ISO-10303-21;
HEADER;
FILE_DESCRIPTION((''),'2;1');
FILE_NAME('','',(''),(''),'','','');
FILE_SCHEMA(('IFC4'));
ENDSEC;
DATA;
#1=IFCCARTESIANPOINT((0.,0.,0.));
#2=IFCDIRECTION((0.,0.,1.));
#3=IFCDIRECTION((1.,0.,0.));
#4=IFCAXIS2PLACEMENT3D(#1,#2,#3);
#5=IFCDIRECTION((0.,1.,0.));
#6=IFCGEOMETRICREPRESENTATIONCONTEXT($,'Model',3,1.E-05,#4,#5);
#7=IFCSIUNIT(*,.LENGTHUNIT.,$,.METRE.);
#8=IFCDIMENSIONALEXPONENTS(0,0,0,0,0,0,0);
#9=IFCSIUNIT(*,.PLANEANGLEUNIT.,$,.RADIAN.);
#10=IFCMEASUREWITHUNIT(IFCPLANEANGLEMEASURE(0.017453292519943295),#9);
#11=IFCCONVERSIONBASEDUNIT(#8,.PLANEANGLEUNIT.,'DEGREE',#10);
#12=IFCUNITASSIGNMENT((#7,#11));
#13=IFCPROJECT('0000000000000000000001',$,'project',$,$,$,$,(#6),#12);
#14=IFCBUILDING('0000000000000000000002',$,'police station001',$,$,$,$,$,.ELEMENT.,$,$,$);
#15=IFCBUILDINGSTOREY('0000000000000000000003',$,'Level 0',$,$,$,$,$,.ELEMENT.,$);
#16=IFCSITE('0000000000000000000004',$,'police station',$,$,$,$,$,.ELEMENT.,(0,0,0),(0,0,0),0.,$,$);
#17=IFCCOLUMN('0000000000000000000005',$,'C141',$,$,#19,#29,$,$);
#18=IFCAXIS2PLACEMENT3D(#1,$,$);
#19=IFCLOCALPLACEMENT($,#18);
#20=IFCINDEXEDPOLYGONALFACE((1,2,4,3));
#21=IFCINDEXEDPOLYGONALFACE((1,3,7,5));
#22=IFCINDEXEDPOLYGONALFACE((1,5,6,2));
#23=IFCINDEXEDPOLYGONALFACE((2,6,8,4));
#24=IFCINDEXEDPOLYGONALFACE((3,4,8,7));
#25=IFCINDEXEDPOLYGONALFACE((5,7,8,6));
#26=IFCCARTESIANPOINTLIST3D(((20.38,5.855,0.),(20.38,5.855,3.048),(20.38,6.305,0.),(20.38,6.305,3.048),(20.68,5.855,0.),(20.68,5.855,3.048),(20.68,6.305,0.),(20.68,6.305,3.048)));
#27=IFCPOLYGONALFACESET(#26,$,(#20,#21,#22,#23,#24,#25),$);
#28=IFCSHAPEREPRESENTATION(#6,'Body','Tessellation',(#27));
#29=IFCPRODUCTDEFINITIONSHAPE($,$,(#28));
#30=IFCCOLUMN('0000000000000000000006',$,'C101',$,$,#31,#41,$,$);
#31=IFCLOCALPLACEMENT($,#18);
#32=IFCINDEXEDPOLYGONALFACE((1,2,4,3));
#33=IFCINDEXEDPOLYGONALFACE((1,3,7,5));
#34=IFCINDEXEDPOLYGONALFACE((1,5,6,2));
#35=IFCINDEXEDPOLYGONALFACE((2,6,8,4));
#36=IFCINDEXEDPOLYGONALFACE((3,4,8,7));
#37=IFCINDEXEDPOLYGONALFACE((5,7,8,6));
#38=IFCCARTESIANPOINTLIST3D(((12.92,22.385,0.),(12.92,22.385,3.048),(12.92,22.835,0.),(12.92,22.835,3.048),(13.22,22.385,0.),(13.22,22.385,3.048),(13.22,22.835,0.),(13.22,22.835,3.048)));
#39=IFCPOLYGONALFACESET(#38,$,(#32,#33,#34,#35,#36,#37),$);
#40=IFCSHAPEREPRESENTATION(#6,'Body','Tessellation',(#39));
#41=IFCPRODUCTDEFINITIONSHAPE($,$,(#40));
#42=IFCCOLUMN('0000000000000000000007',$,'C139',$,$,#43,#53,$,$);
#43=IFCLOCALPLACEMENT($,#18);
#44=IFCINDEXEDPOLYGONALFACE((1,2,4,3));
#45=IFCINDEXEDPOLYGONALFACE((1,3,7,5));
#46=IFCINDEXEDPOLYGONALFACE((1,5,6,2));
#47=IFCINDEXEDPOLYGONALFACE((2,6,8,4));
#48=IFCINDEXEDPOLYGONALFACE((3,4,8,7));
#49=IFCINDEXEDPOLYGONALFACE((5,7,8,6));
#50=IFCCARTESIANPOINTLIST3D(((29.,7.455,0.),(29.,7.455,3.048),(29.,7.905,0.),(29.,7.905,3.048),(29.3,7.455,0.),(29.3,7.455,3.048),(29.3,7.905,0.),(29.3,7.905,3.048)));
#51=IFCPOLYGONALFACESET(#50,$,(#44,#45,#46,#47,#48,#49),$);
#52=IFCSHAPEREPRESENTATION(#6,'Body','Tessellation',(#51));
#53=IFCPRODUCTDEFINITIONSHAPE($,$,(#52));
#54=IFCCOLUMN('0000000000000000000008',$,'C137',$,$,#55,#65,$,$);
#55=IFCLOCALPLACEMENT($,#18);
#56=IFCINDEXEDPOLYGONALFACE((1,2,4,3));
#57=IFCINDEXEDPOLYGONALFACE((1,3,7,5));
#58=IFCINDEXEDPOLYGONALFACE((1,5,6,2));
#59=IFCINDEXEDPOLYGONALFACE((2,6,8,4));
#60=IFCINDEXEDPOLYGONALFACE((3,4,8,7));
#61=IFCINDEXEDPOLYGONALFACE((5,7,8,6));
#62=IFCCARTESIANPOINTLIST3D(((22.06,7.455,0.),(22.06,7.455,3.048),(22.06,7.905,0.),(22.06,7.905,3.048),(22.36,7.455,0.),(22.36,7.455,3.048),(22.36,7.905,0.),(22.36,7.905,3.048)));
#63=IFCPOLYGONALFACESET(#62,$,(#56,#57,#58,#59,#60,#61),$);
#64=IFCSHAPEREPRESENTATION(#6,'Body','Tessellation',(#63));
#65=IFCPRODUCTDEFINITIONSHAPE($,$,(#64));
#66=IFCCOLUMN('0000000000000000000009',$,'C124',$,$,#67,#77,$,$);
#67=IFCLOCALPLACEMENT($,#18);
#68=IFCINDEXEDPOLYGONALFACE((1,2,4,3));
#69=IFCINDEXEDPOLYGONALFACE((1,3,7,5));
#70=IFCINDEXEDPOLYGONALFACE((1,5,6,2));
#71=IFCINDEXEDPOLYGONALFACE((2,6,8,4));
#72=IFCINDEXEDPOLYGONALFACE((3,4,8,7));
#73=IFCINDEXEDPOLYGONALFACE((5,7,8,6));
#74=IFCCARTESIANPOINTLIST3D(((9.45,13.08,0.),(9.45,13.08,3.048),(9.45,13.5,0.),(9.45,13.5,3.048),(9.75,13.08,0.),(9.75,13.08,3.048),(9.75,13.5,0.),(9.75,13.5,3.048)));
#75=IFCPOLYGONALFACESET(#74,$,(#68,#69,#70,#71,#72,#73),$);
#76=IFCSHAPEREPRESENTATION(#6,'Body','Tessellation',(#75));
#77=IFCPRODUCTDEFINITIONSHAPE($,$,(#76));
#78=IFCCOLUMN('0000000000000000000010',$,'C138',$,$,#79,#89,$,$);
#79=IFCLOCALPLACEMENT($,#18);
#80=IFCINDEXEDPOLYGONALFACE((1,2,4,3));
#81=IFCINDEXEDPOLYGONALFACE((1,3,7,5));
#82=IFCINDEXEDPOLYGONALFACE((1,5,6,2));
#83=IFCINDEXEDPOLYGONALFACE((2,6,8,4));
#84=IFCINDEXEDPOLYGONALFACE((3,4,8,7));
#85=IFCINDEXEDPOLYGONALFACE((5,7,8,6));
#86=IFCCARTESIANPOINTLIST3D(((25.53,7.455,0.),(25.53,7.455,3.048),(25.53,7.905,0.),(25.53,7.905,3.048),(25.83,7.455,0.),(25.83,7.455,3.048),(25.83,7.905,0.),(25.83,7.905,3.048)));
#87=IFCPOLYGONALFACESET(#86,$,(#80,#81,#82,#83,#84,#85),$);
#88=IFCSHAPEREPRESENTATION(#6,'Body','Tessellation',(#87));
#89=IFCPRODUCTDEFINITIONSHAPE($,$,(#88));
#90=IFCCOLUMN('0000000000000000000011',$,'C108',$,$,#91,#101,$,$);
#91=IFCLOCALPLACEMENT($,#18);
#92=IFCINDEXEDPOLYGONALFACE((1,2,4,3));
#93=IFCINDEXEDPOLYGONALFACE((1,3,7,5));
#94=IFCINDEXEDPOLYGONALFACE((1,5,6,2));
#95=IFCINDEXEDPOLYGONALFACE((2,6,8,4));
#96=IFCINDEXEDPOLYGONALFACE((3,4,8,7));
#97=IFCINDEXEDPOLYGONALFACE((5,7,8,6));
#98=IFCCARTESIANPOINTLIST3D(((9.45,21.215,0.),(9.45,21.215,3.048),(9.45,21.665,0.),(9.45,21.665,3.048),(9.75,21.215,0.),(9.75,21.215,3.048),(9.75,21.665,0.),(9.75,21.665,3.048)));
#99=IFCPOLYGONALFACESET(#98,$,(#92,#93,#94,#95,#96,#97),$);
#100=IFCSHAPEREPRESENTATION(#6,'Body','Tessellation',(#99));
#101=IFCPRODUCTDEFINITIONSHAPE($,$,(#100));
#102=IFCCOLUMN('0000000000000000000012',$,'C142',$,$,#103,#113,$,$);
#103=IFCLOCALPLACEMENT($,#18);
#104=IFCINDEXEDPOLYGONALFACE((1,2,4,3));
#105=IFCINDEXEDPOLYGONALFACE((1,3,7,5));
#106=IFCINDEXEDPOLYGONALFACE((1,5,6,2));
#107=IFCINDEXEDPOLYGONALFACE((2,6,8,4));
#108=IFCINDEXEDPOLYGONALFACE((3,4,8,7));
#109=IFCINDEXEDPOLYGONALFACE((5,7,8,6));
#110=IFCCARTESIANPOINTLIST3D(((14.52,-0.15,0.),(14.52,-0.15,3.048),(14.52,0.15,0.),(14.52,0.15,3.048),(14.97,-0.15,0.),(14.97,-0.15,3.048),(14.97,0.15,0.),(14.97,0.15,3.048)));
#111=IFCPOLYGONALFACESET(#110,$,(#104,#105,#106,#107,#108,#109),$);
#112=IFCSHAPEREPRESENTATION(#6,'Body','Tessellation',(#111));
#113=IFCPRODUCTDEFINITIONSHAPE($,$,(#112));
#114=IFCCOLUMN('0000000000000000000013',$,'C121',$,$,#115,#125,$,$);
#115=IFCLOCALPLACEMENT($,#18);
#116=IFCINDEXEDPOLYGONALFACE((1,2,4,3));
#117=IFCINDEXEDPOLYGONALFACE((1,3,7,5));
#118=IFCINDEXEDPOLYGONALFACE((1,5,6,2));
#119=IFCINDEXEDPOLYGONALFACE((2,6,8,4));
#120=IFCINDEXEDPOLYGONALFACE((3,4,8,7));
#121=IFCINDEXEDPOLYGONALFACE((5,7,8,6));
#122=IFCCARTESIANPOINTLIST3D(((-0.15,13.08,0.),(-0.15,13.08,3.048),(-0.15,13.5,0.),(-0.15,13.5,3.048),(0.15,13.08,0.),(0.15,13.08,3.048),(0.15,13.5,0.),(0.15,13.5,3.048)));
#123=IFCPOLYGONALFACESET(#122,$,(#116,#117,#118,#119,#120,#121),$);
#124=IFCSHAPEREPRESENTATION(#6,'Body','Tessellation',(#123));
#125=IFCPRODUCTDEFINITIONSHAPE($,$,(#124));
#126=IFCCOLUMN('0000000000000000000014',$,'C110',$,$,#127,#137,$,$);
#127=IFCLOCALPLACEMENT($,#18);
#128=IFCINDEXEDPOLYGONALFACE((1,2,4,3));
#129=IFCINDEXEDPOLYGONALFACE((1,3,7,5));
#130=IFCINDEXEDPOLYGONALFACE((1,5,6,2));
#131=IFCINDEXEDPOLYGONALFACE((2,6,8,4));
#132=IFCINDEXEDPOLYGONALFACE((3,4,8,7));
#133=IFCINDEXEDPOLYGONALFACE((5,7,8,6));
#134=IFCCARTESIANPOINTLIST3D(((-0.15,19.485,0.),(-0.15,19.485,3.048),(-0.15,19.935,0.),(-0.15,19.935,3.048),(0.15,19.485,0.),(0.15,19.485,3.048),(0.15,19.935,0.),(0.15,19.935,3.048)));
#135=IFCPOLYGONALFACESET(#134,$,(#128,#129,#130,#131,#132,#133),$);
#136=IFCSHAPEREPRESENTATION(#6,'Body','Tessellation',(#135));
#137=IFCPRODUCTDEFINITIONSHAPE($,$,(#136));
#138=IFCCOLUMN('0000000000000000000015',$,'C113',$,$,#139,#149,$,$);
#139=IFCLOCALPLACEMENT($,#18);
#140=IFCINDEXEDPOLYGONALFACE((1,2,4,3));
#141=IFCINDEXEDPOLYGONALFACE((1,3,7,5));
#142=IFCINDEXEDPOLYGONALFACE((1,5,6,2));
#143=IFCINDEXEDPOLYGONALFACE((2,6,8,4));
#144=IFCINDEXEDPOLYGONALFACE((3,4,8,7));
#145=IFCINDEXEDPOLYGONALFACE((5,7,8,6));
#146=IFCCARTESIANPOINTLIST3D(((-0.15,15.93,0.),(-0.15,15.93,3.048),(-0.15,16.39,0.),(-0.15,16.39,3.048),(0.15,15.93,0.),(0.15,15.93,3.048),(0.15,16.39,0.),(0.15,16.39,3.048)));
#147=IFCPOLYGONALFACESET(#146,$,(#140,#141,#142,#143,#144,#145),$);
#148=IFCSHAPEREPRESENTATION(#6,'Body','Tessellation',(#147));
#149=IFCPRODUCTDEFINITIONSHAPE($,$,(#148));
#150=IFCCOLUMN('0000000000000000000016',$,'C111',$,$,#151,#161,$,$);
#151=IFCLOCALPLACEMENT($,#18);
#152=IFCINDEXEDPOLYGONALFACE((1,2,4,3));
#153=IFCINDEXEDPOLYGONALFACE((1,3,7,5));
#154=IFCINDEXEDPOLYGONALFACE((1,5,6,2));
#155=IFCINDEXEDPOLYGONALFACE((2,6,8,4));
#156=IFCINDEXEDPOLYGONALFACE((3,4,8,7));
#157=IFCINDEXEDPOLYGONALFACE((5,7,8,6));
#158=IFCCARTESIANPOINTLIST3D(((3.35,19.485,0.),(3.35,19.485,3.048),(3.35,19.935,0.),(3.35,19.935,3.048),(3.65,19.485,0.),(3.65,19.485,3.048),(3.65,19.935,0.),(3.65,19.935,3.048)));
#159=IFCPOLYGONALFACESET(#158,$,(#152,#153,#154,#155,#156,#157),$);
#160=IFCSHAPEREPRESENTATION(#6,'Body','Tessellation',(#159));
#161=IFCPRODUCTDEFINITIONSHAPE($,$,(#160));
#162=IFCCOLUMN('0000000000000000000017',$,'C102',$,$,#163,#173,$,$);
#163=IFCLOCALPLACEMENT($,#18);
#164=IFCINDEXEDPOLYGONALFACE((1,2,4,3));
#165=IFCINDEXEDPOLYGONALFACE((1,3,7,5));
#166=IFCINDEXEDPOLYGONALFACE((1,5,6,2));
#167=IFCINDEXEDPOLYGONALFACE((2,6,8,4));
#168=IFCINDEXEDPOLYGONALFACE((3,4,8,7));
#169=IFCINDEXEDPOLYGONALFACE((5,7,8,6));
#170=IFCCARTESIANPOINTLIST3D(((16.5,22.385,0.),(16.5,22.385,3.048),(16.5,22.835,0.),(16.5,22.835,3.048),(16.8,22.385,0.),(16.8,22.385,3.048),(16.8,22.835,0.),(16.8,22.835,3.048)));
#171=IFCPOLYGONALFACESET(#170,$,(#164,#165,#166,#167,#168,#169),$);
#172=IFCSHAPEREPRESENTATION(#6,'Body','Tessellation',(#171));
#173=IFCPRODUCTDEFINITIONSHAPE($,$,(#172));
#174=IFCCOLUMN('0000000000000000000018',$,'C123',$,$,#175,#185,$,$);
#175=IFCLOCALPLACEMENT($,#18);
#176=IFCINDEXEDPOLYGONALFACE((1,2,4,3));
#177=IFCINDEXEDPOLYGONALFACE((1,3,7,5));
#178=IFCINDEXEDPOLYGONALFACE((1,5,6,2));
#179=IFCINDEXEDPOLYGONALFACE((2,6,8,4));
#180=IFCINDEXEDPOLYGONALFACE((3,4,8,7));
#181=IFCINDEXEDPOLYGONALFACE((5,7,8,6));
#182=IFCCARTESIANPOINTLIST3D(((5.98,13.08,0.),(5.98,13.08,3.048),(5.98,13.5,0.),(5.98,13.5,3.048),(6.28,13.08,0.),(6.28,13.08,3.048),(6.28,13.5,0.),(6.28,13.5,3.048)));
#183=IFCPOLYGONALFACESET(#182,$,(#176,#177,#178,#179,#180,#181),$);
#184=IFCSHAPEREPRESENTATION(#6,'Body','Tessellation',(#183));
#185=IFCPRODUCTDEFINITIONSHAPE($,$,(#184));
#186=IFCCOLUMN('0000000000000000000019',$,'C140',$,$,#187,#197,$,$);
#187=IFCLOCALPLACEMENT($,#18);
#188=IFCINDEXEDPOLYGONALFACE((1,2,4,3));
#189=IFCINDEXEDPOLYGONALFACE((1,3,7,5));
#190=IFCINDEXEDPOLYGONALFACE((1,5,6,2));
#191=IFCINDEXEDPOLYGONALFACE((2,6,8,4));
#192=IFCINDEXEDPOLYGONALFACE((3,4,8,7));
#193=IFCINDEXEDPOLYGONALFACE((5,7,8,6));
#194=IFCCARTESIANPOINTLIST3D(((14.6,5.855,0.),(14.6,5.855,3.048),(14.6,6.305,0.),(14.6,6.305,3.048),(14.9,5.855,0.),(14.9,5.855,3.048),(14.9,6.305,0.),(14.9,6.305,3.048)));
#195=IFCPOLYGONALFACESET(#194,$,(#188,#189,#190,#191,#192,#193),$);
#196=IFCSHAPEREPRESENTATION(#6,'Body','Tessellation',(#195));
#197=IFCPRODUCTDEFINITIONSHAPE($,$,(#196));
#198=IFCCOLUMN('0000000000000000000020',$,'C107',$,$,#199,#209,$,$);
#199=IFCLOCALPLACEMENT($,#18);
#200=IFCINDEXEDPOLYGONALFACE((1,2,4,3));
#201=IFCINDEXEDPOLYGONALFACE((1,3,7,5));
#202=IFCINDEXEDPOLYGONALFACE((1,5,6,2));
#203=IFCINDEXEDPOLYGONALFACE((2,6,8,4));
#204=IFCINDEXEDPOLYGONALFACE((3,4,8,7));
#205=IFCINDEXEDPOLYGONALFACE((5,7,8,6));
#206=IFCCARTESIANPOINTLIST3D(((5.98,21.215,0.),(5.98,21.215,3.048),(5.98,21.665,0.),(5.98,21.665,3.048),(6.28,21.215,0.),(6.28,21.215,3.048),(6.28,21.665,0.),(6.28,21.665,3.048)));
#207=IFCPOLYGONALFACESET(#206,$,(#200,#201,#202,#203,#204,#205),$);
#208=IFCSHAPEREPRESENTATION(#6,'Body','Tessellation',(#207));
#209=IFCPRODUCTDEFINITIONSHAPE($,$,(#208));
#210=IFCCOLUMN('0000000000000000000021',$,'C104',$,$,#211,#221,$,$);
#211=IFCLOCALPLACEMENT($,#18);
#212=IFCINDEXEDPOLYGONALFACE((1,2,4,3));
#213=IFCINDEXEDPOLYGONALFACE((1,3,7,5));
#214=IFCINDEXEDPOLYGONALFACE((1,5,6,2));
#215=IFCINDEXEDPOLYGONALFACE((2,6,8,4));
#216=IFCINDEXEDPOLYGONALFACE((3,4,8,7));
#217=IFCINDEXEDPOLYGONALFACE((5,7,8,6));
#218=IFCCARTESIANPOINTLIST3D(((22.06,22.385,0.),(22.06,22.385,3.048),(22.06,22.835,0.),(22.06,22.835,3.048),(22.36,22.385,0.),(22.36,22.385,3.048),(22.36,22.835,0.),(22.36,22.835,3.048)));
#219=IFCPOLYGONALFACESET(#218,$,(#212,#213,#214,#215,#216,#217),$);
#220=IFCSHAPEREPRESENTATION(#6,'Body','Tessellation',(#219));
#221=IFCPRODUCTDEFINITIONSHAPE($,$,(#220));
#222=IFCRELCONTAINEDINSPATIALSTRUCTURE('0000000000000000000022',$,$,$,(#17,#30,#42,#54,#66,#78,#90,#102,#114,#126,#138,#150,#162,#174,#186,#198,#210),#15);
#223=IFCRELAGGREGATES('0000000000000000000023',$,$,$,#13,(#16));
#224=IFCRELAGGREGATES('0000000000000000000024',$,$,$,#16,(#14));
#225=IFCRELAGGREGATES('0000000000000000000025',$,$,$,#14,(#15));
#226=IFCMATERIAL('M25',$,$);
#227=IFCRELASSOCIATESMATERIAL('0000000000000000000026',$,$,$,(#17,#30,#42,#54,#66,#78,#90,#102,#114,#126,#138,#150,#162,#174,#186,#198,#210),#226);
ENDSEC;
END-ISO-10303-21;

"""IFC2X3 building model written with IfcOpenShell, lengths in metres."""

from ifc_helpers import new_model, entity, si_unit, converted_unit, direction, frame, frame_2d, origin_with_axes, place, context, project, spatial, rectangle, extrude, material, element, save


model = new_model("IFC2X3")

# Units and contexts
model_context = context("Model", 3, precision=1e-05, world=origin_with_axes(), true_north=direction((0.0, 1.0, 0.0)))
ifc_project = project(units=[si_unit("LENGTHUNIT", "METRE"), converted_unit("PLANEANGLEUNIT", "DEGREE", entity("IfcPlaneAngleMeasure", 0.017453292519943295), si_unit("PLANEANGLEUNIT", "RADIAN"), dimensions=[0, 0, 0, 0, 0, 0, 0])], contexts=[model_context])

# Site, building, storey
site = spatial("IfcSite", under=ifc_project, Name="police station", CompositionType="ELEMENT", RefLatitude=(0, 0, 0), RefLongitude=(0, 0, 0), RefElevation=0.0)
building = spatial("IfcBuilding", under=site, Name="police station001", CompositionType="ELEMENT")
storey = spatial("IfcBuildingStorey", under=building, Name="Level 0", CompositionType="ELEMENT")

# Columns
ifc_material = material(Name="M25")
placement = place(None, origin_with_axes())
element("IfcColumn", 1, at=placement, inside=storey, material=ifc_material, Name="C141", context=model_context, shape_type="SweptSolid", body=[
    extrude(rectangle(XDim=0.3, YDim=0.45, at=frame_2d((0.0, 0.0), x_axis=(1.0, 0.0, 0.0))), frame((20.53, 6.08, 0.0), z_axis=(0.0, 0.0, 1.0), x_axis=(1.0, 0.0, 0.0)), (0.0, 0.0, 1.0), 3.048),
])
element("IfcColumn", 2, at=placement, inside=storey, material=ifc_material, Name="C101", context=model_context, shape_type="SweptSolid", body=[
    extrude(rectangle(XDim=0.3, YDim=0.45, at=frame_2d((0.0, 0.0), x_axis=(1.0, 0.0, 0.0))), frame((13.07, 22.61, 0.0), z_axis=(0.0, 0.0, 1.0), x_axis=(1.0, 0.0, 0.0)), (0.0, 0.0, 1.0), 3.048),
])
element("IfcColumn", 3, at=placement, inside=storey, material=ifc_material, Name="C139", context=model_context, shape_type="SweptSolid", body=[
    extrude(rectangle(XDim=0.3, YDim=0.45, at=frame_2d((0.0, 0.0), x_axis=(1.0, 0.0, 0.0))), frame((29.15, 7.68, 0.0), z_axis=(0.0, 0.0, 1.0), x_axis=(1.0, 0.0, 0.0)), (0.0, 0.0, 1.0), 3.048),
])
element("IfcColumn", 4, at=placement, inside=storey, material=ifc_material, Name="C137", context=model_context, shape_type="SweptSolid", body=[
    extrude(rectangle(XDim=0.3, YDim=0.45, at=frame_2d((0.0, 0.0), x_axis=(1.0, 0.0, 0.0))), frame((22.21, 7.68, 0.0), z_axis=(0.0, 0.0, 1.0), x_axis=(1.0, 0.0, 0.0)), (0.0, 0.0, 1.0), 3.048),
])
element("IfcColumn", 5, at=placement, inside=storey, material=ifc_material, Name="C124", context=model_context, shape_type="SweptSolid", body=[
    extrude(rectangle(XDim=0.3, YDim=0.42, at=frame_2d((0.0, 0.0), x_axis=(1.0, 0.0, 0.0))), frame((9.6, 13.29, 0.0), z_axis=(0.0, 0.0, 1.0), x_axis=(1.0, 0.0, 0.0)), (0.0, 0.0, 1.0), 3.048),
])
element("IfcColumn", 6, at=placement, inside=storey, material=ifc_material, Name="C138", context=model_context, shape_type="SweptSolid", body=[
    extrude(rectangle(XDim=0.3, YDim=0.45, at=frame_2d((0.0, 0.0), x_axis=(1.0, 0.0, 0.0))), frame((25.68, 7.68, 0.0), z_axis=(0.0, 0.0, 1.0), x_axis=(1.0, 0.0, 0.0)), (0.0, 0.0, 1.0), 3.048),
])
element("IfcColumn", 7, at=placement, inside=storey, material=ifc_material, Name="C108", context=model_context, shape_type="SweptSolid", body=[
    extrude(rectangle(XDim=0.3, YDim=0.45, at=frame_2d((0.0, 0.0), x_axis=(1.0, 0.0, 0.0))), frame((9.6, 21.44, 0.0), z_axis=(0.0, 0.0, 1.0), x_axis=(1.0, 0.0, 0.0)), (0.0, 0.0, 1.0), 3.048),
])
element("IfcColumn", 8, at=placement, inside=storey, material=ifc_material, Name="C142", context=model_context, shape_type="SweptSolid", body=[
    extrude(rectangle(XDim=0.45, YDim=0.3, at=frame_2d((0.0, 0.0), x_axis=(1.0, 0.0, 0.0))), frame((14.745, 0.0, 0.0), z_axis=(0.0, 0.0, 1.0), x_axis=(1.0, 0.0, 0.0)), (0.0, 0.0, 1.0), 3.048),
])
element("IfcColumn", 9, at=placement, inside=storey, material=ifc_material, Name="C121", context=model_context, shape_type="SweptSolid", body=[
    extrude(rectangle(XDim=0.3, YDim=0.42, at=frame_2d((0.0, 0.0), x_axis=(1.0, 0.0, 0.0))), frame((0.0, 13.29, 0.0), z_axis=(0.0, 0.0, 1.0), x_axis=(1.0, 0.0, 0.0)), (0.0, 0.0, 1.0), 3.048),
])
element("IfcColumn", 10, at=placement, inside=storey, material=ifc_material, Name="C110", context=model_context, shape_type="SweptSolid", body=[
    extrude(rectangle(XDim=0.3, YDim=0.45, at=frame_2d((0.0, 0.0), x_axis=(1.0, 0.0, 0.0))), frame((0.0, 19.71, 0.0), z_axis=(0.0, 0.0, 1.0), x_axis=(1.0, 0.0, 0.0)), (0.0, 0.0, 1.0), 3.048),
])
element("IfcColumn", 11, at=placement, inside=storey, material=ifc_material, Name="C113", context=model_context, shape_type="SweptSolid", body=[
    extrude(rectangle(XDim=0.3, YDim=0.46, at=frame_2d((0.0, 0.0), x_axis=(1.0, 0.0, 0.0))), frame((0.0, 16.16, 0.0), z_axis=(0.0, 0.0, 1.0), x_axis=(1.0, 0.0, 0.0)), (0.0, 0.0, 1.0), 3.048),
])
element("IfcColumn", 12, at=placement, inside=storey, material=ifc_material, Name="C111", context=model_context, shape_type="SweptSolid", body=[
    extrude(rectangle(XDim=0.3, YDim=0.45, at=frame_2d((0.0, 0.0), x_axis=(1.0, 0.0, 0.0))), frame((3.5, 19.71, 0.0), z_axis=(0.0, 0.0, 1.0), x_axis=(1.0, 0.0, 0.0)), (0.0, 0.0, 1.0), 3.048),
])
element("IfcColumn", 13, at=placement, inside=storey, material=ifc_material, Name="C102", context=model_context, shape_type="SweptSolid", body=[
    extrude(rectangle(XDim=0.3, YDim=0.45, at=frame_2d((0.0, 0.0), x_axis=(1.0, 0.0, 0.0))), frame((16.65, 22.61, 0.0), z_axis=(0.0, 0.0, 1.0), x_axis=(1.0, 0.0, 0.0)), (0.0, 0.0, 1.0), 3.048),
])
element("IfcColumn", 14, at=placement, inside=storey, material=ifc_material, Name="C123", context=model_context, shape_type="SweptSolid", body=[
    extrude(rectangle(XDim=0.3, YDim=0.42, at=frame_2d((0.0, 0.0), x_axis=(1.0, 0.0, 0.0))), frame((6.13, 13.29, 0.0), z_axis=(0.0, 0.0, 1.0), x_axis=(1.0, 0.0, 0.0)), (0.0, 0.0, 1.0), 3.048),
])
element("IfcColumn", 15, at=placement, inside=storey, material=ifc_material, Name="C140", context=model_context, shape_type="SweptSolid", body=[
    extrude(rectangle(XDim=0.3, YDim=0.45, at=frame_2d((0.0, 0.0), x_axis=(1.0, 0.0, 0.0))), frame((14.75, 6.08, 0.0), z_axis=(0.0, 0.0, 1.0), x_axis=(1.0, 0.0, 0.0)), (0.0, 0.0, 1.0), 3.048),
])
element("IfcColumn", 16, at=placement, inside=storey, material=ifc_material, Name="C107", context=model_context, shape_type="SweptSolid", body=[
    extrude(rectangle(XDim=0.3, YDim=0.45, at=frame_2d((0.0, 0.0), x_axis=(1.0, 0.0, 0.0))), frame((6.13, 21.44, 0.0), z_axis=(0.0, 0.0, 1.0), x_axis=(1.0, 0.0, 0.0)), (0.0, 0.0, 1.0), 3.048),
])
element("IfcColumn", 17, at=placement, inside=storey, material=ifc_material, Name="C104", context=model_context, shape_type="SweptSolid", body=[
    extrude(rectangle(XDim=0.3, YDim=0.45, at=frame_2d((0.0, 0.0), x_axis=(1.0, 0.0, 0.0))), frame((22.21, 22.61, 0.0), z_axis=(0.0, 0.0, 1.0), x_axis=(1.0, 0.0, 0.0)), (0.0, 0.0, 1.0), 3.048),
])

save(model, "model.ifc")
